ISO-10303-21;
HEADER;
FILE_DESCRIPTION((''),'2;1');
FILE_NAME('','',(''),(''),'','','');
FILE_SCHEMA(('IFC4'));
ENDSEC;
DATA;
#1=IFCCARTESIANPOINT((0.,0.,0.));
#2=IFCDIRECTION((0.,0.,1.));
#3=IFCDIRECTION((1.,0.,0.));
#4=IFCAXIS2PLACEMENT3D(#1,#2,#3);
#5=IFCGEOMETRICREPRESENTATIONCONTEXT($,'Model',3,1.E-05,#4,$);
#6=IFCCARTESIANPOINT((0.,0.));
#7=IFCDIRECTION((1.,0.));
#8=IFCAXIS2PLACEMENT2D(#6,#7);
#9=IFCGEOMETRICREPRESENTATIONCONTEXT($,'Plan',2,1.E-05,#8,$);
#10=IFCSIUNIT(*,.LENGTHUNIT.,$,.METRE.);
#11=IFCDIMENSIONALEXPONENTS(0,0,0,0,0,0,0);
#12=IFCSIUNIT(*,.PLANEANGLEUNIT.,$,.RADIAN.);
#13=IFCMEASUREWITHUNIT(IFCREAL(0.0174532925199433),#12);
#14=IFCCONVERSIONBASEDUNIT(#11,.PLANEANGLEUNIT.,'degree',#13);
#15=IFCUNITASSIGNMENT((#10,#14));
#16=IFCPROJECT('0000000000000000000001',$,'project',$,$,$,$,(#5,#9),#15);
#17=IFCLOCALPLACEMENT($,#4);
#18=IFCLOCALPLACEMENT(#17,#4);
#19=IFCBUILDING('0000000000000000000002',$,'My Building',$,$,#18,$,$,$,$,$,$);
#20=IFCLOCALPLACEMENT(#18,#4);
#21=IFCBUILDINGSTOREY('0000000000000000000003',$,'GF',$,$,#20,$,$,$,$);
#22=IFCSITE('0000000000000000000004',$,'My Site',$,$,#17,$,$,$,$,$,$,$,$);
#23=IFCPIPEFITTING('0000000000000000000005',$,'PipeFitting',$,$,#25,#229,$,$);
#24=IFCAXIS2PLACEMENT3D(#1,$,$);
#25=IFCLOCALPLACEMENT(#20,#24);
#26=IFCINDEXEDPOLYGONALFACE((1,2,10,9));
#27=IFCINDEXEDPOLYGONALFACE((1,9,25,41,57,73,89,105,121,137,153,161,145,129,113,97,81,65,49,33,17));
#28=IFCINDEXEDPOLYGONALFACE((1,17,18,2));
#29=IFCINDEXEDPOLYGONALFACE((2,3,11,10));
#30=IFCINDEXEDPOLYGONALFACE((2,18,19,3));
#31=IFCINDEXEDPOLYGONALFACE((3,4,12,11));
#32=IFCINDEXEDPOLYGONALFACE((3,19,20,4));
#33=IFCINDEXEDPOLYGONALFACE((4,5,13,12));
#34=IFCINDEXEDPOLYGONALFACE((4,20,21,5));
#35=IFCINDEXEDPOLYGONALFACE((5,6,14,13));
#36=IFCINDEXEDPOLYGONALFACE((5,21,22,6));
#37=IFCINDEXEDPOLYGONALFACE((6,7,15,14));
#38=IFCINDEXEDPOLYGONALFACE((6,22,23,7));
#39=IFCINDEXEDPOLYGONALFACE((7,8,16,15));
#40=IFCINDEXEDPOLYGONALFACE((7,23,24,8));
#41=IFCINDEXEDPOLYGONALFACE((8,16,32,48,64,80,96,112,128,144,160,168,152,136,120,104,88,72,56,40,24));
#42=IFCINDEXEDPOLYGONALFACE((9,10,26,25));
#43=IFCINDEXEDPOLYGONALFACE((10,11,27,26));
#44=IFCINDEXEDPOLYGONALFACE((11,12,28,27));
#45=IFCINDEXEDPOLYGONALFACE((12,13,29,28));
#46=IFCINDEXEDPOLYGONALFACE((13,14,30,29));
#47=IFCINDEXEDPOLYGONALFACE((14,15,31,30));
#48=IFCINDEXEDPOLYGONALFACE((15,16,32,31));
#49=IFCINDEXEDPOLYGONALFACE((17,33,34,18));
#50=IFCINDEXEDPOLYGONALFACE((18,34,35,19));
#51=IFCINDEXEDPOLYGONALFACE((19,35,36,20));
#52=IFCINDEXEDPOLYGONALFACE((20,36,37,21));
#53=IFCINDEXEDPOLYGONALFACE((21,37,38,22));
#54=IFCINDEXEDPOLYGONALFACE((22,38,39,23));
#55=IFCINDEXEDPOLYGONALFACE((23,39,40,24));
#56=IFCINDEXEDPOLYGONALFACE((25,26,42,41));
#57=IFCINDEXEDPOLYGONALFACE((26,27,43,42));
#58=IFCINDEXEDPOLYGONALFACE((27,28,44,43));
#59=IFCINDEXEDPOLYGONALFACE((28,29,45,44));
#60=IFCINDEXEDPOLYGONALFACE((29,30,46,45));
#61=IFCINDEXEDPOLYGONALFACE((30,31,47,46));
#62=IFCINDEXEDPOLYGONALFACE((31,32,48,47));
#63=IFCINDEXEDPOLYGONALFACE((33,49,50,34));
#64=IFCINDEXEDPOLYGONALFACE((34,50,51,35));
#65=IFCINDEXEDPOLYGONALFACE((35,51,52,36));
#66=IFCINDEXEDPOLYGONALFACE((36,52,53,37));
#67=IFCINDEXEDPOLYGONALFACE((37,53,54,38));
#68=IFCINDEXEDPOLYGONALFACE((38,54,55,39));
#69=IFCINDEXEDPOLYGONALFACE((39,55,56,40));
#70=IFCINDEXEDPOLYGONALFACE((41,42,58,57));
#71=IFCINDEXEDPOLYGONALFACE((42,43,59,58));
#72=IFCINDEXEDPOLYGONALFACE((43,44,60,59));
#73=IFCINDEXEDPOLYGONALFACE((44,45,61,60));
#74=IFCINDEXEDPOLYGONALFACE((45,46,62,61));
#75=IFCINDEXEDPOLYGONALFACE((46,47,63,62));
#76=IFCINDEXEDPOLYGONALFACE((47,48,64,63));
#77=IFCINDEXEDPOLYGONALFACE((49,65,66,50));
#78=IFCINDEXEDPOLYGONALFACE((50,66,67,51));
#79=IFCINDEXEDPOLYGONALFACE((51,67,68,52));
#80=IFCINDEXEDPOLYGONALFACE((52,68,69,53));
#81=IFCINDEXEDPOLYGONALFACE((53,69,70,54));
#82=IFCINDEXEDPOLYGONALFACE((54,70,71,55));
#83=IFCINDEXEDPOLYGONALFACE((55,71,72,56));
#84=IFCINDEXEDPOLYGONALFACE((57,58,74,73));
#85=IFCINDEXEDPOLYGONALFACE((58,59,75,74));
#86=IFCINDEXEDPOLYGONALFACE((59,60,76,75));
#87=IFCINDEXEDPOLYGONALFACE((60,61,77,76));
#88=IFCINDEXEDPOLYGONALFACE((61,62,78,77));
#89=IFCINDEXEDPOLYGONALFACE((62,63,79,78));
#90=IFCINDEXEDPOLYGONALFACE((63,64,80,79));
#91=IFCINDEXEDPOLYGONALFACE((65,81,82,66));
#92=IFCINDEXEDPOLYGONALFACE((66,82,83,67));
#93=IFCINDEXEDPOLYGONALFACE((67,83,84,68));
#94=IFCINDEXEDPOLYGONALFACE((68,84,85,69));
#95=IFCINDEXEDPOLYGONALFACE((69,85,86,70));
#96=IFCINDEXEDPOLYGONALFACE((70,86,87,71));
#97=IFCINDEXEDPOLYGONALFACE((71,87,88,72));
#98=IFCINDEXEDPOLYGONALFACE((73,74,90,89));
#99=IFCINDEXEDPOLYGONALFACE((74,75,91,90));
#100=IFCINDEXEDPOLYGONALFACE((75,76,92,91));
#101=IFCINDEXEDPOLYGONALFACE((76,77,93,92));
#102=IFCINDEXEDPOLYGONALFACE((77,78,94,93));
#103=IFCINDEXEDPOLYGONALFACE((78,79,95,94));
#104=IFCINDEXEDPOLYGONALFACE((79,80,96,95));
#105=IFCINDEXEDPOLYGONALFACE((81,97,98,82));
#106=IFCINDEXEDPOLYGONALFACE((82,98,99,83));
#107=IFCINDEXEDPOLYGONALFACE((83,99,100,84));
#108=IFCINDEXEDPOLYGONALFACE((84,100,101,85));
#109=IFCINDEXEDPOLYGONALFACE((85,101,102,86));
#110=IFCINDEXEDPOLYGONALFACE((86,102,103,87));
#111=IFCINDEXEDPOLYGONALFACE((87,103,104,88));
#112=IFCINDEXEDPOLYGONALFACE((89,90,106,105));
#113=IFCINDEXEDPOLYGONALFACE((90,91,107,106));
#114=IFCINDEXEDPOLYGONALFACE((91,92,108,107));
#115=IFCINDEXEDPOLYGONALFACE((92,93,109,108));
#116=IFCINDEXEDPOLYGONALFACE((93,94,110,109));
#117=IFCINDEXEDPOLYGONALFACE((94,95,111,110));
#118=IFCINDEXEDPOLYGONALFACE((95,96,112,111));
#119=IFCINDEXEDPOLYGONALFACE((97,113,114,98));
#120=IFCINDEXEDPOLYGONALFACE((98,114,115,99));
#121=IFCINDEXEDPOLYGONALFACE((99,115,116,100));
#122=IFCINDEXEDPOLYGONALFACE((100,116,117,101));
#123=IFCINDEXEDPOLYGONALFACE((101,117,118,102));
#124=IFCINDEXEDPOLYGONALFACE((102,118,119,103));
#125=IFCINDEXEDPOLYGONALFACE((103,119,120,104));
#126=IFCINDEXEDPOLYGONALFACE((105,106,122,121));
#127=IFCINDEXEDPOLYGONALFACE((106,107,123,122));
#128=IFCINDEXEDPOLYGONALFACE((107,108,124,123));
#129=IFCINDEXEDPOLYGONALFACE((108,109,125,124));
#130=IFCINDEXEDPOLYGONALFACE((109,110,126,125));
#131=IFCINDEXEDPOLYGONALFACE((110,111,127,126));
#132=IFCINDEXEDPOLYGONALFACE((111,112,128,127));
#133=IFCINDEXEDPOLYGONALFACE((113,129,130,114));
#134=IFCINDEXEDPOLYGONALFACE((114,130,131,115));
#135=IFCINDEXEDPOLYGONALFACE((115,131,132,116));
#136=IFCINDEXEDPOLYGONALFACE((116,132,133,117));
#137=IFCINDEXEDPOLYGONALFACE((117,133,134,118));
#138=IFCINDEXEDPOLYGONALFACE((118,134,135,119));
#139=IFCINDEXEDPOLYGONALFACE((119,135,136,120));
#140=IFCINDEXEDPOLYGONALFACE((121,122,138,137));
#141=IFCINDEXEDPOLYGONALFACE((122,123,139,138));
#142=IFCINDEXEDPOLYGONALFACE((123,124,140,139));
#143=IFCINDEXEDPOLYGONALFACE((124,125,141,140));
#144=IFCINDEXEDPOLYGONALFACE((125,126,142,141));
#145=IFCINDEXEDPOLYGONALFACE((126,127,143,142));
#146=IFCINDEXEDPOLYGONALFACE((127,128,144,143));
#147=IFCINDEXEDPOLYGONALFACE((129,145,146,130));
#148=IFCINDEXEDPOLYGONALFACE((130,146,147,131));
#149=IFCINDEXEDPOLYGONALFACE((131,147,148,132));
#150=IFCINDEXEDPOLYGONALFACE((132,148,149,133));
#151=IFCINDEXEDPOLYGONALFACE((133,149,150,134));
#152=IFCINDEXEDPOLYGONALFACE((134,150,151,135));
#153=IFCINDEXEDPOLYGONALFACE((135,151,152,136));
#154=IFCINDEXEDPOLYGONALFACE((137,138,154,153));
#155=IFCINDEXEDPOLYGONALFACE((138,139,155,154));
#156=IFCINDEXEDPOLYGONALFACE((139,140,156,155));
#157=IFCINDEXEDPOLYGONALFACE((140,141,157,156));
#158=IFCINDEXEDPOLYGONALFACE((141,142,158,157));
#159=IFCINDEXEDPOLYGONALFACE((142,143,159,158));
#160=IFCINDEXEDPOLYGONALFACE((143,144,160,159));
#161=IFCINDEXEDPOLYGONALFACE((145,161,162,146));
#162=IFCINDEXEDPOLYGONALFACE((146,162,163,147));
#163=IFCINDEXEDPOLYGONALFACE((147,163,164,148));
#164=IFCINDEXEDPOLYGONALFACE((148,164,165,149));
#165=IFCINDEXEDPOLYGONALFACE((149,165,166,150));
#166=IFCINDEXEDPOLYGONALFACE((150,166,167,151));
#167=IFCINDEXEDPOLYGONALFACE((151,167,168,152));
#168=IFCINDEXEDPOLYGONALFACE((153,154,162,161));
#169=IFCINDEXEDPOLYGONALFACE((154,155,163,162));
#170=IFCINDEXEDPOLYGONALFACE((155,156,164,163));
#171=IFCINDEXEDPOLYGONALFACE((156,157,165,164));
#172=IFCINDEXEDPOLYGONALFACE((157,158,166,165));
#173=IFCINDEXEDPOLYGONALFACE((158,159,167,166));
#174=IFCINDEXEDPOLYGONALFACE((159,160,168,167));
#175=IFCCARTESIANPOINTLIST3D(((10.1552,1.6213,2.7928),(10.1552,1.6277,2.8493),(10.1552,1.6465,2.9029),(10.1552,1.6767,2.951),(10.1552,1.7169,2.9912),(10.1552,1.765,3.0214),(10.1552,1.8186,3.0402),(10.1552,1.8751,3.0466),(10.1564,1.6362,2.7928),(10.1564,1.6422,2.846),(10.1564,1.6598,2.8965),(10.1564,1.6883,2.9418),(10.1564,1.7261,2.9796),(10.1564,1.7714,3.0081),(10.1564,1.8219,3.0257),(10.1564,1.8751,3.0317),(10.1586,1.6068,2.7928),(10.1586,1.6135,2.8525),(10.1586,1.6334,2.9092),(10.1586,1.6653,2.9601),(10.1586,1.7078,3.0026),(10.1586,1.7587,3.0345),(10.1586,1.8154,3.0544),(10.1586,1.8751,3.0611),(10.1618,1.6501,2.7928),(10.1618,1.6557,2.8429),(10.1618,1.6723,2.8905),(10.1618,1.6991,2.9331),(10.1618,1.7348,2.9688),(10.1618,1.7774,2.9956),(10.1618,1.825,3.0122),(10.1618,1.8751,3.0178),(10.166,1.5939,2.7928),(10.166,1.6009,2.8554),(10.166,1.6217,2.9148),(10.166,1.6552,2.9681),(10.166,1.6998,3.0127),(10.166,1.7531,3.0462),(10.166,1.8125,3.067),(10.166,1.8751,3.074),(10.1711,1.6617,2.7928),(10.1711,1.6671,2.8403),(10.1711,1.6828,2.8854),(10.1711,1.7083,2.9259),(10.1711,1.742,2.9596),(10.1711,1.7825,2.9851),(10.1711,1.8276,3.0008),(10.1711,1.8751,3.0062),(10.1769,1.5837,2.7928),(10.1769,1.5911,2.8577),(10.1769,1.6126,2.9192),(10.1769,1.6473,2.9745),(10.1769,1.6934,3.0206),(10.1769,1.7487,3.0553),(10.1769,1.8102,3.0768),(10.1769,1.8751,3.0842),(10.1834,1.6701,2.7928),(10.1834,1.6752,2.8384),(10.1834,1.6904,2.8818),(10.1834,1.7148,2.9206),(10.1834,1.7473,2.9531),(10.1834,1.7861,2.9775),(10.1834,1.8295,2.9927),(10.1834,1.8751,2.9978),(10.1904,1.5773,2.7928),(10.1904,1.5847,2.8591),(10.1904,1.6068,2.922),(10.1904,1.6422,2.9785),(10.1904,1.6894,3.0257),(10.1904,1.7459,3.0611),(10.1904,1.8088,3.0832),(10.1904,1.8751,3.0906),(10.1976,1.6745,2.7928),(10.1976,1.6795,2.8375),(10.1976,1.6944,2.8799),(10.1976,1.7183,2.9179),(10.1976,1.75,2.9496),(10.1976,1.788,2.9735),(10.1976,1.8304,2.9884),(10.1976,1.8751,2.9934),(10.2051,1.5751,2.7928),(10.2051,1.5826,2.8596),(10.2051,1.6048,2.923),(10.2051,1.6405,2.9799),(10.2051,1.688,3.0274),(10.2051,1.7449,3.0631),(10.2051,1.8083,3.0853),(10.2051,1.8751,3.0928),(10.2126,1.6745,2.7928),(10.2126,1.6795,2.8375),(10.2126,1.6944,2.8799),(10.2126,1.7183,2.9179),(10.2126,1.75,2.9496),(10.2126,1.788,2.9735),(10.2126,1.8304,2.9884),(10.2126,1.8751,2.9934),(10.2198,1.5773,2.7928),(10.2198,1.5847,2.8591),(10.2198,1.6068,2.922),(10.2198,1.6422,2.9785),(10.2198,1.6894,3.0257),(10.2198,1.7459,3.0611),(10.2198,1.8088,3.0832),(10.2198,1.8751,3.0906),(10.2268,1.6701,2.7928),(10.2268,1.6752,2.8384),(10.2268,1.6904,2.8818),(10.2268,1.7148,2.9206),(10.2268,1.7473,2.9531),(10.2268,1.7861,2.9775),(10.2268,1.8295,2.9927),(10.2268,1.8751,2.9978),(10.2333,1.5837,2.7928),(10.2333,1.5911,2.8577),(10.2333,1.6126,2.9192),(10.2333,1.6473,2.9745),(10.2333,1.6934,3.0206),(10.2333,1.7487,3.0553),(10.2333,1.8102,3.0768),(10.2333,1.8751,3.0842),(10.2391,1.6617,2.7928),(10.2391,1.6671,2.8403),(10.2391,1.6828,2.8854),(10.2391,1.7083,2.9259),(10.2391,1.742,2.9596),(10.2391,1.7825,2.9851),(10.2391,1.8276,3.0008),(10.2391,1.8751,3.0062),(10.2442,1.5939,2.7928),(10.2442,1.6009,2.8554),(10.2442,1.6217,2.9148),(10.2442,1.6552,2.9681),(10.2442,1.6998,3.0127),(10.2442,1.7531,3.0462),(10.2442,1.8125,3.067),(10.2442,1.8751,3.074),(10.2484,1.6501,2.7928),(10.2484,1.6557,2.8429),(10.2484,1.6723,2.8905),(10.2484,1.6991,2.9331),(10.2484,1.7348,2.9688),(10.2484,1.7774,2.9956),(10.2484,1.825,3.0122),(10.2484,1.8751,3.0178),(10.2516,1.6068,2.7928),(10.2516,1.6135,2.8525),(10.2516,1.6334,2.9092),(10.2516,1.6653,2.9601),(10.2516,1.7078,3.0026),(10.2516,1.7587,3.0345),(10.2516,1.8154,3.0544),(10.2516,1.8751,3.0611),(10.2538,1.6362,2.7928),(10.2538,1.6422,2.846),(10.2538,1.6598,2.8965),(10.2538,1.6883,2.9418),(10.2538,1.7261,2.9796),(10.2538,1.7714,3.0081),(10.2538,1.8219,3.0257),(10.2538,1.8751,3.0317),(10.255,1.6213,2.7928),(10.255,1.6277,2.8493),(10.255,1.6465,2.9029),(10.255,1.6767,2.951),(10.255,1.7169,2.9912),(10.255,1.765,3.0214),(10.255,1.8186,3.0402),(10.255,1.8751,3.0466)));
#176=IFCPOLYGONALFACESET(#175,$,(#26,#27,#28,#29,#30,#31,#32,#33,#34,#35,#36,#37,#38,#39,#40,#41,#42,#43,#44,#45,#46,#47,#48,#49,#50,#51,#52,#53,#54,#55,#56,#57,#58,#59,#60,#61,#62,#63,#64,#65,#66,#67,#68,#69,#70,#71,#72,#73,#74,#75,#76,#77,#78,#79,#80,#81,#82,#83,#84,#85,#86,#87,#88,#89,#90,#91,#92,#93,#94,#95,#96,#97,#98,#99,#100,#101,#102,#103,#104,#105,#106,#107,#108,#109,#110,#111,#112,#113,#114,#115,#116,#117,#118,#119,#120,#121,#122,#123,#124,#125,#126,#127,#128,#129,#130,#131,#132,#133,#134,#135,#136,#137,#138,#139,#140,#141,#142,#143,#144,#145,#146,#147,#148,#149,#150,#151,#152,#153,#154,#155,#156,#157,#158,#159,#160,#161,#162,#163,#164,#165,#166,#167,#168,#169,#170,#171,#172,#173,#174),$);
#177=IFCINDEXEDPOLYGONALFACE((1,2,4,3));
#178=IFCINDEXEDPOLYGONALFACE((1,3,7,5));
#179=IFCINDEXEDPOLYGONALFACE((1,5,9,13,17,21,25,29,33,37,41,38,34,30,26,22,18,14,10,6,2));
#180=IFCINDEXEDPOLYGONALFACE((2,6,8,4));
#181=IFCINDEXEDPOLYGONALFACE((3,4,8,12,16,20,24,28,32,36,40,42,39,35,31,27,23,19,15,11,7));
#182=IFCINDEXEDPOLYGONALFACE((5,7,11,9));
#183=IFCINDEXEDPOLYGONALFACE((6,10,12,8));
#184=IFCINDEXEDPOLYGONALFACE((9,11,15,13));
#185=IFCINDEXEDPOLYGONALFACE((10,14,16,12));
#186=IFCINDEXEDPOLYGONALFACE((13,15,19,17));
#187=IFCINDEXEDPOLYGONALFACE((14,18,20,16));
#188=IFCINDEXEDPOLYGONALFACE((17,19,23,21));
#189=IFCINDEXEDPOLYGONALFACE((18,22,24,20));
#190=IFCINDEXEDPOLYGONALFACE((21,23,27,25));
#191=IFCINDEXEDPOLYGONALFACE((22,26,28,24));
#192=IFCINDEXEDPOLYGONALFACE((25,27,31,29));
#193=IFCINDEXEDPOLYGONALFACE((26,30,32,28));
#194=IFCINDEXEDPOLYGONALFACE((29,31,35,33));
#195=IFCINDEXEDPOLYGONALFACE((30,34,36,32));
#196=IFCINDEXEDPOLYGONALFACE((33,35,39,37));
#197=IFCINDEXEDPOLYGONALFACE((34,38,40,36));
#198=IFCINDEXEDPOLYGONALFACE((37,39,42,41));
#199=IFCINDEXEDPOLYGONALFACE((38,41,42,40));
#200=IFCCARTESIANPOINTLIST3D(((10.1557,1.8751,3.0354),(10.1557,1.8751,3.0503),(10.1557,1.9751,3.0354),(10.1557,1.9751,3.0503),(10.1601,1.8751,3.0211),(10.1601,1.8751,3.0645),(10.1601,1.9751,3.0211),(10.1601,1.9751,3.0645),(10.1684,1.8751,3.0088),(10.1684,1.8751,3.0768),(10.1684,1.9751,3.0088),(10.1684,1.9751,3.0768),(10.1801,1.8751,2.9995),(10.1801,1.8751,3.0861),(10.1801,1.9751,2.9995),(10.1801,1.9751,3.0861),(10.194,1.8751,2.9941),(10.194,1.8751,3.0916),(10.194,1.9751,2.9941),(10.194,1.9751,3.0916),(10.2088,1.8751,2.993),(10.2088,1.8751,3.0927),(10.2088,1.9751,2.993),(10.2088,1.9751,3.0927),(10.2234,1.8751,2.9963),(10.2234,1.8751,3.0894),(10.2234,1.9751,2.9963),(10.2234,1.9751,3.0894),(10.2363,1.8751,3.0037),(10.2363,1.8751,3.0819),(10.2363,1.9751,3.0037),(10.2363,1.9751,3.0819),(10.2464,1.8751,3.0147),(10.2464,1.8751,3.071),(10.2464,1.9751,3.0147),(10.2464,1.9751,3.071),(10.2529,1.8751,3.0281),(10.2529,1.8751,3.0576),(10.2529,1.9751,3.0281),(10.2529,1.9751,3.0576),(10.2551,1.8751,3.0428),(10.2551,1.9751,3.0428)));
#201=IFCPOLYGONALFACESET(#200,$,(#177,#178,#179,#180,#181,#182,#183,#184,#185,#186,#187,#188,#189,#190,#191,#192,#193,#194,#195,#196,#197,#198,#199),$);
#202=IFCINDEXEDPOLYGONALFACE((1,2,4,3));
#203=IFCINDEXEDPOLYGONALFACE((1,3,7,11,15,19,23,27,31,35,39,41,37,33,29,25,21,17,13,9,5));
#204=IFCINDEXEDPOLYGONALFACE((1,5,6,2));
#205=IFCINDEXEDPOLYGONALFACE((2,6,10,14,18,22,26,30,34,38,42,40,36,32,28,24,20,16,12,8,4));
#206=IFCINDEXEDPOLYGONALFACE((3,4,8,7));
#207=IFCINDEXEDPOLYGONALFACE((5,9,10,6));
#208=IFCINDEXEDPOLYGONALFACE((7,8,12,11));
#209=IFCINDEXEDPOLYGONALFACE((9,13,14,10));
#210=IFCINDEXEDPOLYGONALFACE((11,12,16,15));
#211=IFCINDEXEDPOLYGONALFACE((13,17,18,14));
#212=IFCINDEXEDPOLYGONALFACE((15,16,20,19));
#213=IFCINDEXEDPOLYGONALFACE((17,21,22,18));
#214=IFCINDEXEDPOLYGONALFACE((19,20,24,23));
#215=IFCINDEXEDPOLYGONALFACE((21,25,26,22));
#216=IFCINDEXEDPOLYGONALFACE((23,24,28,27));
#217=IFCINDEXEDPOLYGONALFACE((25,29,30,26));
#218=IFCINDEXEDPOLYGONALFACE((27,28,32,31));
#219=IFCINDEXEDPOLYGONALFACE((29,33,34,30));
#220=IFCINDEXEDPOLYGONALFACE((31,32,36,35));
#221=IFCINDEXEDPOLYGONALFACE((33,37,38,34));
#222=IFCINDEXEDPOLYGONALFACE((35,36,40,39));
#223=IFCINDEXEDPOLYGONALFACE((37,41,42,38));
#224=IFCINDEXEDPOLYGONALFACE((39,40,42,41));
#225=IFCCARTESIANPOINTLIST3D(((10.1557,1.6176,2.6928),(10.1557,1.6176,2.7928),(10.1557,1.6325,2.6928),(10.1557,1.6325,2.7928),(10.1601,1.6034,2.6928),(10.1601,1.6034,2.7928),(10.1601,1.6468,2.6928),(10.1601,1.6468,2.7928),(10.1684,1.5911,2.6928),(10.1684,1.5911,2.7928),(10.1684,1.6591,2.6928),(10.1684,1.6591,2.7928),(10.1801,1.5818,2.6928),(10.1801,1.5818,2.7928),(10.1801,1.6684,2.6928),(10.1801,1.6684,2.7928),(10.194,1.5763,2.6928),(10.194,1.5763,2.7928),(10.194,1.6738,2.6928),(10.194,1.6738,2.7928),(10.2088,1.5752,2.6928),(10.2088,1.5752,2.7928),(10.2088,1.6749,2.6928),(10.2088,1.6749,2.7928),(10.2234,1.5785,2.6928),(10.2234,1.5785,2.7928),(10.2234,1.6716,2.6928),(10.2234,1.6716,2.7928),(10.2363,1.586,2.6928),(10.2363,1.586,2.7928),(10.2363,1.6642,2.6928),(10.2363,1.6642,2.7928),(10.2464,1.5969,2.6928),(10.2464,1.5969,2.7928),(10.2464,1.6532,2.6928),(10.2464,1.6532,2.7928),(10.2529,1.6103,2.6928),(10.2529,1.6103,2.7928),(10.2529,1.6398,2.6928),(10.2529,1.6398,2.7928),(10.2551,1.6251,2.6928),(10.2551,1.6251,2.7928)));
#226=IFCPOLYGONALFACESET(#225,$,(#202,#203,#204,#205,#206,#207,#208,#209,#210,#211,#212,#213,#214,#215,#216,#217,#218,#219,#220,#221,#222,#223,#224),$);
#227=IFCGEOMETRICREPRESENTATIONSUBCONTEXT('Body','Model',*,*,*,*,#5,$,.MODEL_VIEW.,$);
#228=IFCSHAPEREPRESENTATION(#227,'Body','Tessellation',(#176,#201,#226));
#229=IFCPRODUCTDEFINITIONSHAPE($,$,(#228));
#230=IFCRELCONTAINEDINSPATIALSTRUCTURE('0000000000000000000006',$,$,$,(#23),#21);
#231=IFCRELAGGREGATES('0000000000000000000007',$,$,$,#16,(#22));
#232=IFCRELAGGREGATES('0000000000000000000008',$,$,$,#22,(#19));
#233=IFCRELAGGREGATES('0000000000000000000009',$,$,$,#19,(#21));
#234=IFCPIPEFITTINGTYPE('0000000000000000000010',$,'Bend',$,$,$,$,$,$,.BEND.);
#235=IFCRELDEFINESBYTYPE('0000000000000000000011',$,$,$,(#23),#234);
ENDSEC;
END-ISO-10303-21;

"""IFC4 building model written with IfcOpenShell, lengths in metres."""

from ifc_helpers import new_model, entity, si_unit, converted_unit, frame, origin_with_axes, origin_2d_with_axis, place, context, subcontext, project, spatial, line, indexed_curve, circle, outline, extrude, source, transform, mapped, type_object, type_shapes, element, save


model = new_model("IFC4")

# Units and contexts
model_context = context("Model", 3, precision=1e-05, world=origin_with_axes())
plan_context = context("Plan", 2, precision=1e-05, world=origin_2d_with_axis())
body_context = subcontext(model_context, "Body", "Model", "MODEL_VIEW")
ifc_project = project(units=[si_unit("LENGTHUNIT", "METRE"), converted_unit("PLANEANGLEUNIT", "degree", entity("IfcReal", 0.0174532925199433), si_unit("PLANEANGLEUNIT", "RADIAN"), dimensions=[0, 0, 0, 0, 0, 0, 0])], contexts=[model_context, plan_context])

# Site, building, storey
site_placement = place(None, origin_with_axes())
site = spatial("IfcSite", under=ifc_project, at=site_placement, Name="My Site")
building_placement = place(site_placement, origin_with_axes())
building = spatial("IfcBuilding", under=site, at=building_placement, Name="My Building")
storey_placement = place(building_placement, origin_with_axes())
storey = spatial("IfcBuildingStorey", under=building, at=storey_placement, Name="GF")

# Pipe fitting, opening
pipe_fitting_type = type_object("IfcPipeFittingType", Name="Bend", PredefinedType="BEND")
shared_shape = source(origin_with_axes(), body_context, "Body", "SolidModel", [
    entity("IfcSweptDiskSolid", entity("IfcIndexedPolyCurve", entity("IfcCartesianPointList3D", [[0.0, 0.0, 0.1], [0.0, -0.0732, 0.2768], [0.0, -0.25, 0.35]]), [entity("IfcArcIndex", [1, 2, 3])]), 0.05),
    extrude(circle(Radius=0.05), origin_with_axes(), (0.0, 0.0, 1.0), 0.1),
    extrude(circle(Radius=0.05), frame((0.0, -0.25, 0.35), z_axis=(0.0, -1.0, 0.0), x_axis=(1.0, 0.0, 0.0)), (0.0, 0.0, 1.0), 0.1),
])
type_shapes(pipe_fitting_type, [shared_shape])
pipe_fitting_1_placement = place(storey_placement, frame((10.2051, 1.9751, 3.0428), z_axis=(0.0, -1.0, 0.0), x_axis=(1.0, 0.0, 0.0)))
pipe_fitting_1 = element("IfcPipeFitting", 1, at=pipe_fitting_1_placement, inside=storey, type_object=pipe_fitting_type, Name="PipeFitting", context=body_context, shape_type="MappedRepresentation", body=[
    mapped(shared_shape, transform((0.0, 0.0, 0.0), x_axis=(1.0, 0.0, 0.0), y_axis=(0.0, 1.0, 0.0), z_axis=(0.0, 0.0, 1.0), scale=1.0)),
])
opening_1_placement = place(pipe_fitting_1_placement, frame((-10.2051, -3.0428, 1.9751), z_axis=(0.0, 1.0, 0.0), x_axis=(1.0, 0.0, 0.0)))
element("IfcOpeningElement", 2, at=opening_1_placement, cuts=pipe_fitting_1, PredefinedType="OPENING", context=body_context, shape_type="SweptSolid", body=[
    extrude(outline(indexed_curve([(0.0, 0.0), (0.5, 0.0), (0.5, 0.5), (0.0, 0.5)], segments=[line(1, 2, 3, 4, 1)])), origin_with_axes(), (0.0, 0.0, 1.0), 0.5),
])

save(model, "model.ifc")
